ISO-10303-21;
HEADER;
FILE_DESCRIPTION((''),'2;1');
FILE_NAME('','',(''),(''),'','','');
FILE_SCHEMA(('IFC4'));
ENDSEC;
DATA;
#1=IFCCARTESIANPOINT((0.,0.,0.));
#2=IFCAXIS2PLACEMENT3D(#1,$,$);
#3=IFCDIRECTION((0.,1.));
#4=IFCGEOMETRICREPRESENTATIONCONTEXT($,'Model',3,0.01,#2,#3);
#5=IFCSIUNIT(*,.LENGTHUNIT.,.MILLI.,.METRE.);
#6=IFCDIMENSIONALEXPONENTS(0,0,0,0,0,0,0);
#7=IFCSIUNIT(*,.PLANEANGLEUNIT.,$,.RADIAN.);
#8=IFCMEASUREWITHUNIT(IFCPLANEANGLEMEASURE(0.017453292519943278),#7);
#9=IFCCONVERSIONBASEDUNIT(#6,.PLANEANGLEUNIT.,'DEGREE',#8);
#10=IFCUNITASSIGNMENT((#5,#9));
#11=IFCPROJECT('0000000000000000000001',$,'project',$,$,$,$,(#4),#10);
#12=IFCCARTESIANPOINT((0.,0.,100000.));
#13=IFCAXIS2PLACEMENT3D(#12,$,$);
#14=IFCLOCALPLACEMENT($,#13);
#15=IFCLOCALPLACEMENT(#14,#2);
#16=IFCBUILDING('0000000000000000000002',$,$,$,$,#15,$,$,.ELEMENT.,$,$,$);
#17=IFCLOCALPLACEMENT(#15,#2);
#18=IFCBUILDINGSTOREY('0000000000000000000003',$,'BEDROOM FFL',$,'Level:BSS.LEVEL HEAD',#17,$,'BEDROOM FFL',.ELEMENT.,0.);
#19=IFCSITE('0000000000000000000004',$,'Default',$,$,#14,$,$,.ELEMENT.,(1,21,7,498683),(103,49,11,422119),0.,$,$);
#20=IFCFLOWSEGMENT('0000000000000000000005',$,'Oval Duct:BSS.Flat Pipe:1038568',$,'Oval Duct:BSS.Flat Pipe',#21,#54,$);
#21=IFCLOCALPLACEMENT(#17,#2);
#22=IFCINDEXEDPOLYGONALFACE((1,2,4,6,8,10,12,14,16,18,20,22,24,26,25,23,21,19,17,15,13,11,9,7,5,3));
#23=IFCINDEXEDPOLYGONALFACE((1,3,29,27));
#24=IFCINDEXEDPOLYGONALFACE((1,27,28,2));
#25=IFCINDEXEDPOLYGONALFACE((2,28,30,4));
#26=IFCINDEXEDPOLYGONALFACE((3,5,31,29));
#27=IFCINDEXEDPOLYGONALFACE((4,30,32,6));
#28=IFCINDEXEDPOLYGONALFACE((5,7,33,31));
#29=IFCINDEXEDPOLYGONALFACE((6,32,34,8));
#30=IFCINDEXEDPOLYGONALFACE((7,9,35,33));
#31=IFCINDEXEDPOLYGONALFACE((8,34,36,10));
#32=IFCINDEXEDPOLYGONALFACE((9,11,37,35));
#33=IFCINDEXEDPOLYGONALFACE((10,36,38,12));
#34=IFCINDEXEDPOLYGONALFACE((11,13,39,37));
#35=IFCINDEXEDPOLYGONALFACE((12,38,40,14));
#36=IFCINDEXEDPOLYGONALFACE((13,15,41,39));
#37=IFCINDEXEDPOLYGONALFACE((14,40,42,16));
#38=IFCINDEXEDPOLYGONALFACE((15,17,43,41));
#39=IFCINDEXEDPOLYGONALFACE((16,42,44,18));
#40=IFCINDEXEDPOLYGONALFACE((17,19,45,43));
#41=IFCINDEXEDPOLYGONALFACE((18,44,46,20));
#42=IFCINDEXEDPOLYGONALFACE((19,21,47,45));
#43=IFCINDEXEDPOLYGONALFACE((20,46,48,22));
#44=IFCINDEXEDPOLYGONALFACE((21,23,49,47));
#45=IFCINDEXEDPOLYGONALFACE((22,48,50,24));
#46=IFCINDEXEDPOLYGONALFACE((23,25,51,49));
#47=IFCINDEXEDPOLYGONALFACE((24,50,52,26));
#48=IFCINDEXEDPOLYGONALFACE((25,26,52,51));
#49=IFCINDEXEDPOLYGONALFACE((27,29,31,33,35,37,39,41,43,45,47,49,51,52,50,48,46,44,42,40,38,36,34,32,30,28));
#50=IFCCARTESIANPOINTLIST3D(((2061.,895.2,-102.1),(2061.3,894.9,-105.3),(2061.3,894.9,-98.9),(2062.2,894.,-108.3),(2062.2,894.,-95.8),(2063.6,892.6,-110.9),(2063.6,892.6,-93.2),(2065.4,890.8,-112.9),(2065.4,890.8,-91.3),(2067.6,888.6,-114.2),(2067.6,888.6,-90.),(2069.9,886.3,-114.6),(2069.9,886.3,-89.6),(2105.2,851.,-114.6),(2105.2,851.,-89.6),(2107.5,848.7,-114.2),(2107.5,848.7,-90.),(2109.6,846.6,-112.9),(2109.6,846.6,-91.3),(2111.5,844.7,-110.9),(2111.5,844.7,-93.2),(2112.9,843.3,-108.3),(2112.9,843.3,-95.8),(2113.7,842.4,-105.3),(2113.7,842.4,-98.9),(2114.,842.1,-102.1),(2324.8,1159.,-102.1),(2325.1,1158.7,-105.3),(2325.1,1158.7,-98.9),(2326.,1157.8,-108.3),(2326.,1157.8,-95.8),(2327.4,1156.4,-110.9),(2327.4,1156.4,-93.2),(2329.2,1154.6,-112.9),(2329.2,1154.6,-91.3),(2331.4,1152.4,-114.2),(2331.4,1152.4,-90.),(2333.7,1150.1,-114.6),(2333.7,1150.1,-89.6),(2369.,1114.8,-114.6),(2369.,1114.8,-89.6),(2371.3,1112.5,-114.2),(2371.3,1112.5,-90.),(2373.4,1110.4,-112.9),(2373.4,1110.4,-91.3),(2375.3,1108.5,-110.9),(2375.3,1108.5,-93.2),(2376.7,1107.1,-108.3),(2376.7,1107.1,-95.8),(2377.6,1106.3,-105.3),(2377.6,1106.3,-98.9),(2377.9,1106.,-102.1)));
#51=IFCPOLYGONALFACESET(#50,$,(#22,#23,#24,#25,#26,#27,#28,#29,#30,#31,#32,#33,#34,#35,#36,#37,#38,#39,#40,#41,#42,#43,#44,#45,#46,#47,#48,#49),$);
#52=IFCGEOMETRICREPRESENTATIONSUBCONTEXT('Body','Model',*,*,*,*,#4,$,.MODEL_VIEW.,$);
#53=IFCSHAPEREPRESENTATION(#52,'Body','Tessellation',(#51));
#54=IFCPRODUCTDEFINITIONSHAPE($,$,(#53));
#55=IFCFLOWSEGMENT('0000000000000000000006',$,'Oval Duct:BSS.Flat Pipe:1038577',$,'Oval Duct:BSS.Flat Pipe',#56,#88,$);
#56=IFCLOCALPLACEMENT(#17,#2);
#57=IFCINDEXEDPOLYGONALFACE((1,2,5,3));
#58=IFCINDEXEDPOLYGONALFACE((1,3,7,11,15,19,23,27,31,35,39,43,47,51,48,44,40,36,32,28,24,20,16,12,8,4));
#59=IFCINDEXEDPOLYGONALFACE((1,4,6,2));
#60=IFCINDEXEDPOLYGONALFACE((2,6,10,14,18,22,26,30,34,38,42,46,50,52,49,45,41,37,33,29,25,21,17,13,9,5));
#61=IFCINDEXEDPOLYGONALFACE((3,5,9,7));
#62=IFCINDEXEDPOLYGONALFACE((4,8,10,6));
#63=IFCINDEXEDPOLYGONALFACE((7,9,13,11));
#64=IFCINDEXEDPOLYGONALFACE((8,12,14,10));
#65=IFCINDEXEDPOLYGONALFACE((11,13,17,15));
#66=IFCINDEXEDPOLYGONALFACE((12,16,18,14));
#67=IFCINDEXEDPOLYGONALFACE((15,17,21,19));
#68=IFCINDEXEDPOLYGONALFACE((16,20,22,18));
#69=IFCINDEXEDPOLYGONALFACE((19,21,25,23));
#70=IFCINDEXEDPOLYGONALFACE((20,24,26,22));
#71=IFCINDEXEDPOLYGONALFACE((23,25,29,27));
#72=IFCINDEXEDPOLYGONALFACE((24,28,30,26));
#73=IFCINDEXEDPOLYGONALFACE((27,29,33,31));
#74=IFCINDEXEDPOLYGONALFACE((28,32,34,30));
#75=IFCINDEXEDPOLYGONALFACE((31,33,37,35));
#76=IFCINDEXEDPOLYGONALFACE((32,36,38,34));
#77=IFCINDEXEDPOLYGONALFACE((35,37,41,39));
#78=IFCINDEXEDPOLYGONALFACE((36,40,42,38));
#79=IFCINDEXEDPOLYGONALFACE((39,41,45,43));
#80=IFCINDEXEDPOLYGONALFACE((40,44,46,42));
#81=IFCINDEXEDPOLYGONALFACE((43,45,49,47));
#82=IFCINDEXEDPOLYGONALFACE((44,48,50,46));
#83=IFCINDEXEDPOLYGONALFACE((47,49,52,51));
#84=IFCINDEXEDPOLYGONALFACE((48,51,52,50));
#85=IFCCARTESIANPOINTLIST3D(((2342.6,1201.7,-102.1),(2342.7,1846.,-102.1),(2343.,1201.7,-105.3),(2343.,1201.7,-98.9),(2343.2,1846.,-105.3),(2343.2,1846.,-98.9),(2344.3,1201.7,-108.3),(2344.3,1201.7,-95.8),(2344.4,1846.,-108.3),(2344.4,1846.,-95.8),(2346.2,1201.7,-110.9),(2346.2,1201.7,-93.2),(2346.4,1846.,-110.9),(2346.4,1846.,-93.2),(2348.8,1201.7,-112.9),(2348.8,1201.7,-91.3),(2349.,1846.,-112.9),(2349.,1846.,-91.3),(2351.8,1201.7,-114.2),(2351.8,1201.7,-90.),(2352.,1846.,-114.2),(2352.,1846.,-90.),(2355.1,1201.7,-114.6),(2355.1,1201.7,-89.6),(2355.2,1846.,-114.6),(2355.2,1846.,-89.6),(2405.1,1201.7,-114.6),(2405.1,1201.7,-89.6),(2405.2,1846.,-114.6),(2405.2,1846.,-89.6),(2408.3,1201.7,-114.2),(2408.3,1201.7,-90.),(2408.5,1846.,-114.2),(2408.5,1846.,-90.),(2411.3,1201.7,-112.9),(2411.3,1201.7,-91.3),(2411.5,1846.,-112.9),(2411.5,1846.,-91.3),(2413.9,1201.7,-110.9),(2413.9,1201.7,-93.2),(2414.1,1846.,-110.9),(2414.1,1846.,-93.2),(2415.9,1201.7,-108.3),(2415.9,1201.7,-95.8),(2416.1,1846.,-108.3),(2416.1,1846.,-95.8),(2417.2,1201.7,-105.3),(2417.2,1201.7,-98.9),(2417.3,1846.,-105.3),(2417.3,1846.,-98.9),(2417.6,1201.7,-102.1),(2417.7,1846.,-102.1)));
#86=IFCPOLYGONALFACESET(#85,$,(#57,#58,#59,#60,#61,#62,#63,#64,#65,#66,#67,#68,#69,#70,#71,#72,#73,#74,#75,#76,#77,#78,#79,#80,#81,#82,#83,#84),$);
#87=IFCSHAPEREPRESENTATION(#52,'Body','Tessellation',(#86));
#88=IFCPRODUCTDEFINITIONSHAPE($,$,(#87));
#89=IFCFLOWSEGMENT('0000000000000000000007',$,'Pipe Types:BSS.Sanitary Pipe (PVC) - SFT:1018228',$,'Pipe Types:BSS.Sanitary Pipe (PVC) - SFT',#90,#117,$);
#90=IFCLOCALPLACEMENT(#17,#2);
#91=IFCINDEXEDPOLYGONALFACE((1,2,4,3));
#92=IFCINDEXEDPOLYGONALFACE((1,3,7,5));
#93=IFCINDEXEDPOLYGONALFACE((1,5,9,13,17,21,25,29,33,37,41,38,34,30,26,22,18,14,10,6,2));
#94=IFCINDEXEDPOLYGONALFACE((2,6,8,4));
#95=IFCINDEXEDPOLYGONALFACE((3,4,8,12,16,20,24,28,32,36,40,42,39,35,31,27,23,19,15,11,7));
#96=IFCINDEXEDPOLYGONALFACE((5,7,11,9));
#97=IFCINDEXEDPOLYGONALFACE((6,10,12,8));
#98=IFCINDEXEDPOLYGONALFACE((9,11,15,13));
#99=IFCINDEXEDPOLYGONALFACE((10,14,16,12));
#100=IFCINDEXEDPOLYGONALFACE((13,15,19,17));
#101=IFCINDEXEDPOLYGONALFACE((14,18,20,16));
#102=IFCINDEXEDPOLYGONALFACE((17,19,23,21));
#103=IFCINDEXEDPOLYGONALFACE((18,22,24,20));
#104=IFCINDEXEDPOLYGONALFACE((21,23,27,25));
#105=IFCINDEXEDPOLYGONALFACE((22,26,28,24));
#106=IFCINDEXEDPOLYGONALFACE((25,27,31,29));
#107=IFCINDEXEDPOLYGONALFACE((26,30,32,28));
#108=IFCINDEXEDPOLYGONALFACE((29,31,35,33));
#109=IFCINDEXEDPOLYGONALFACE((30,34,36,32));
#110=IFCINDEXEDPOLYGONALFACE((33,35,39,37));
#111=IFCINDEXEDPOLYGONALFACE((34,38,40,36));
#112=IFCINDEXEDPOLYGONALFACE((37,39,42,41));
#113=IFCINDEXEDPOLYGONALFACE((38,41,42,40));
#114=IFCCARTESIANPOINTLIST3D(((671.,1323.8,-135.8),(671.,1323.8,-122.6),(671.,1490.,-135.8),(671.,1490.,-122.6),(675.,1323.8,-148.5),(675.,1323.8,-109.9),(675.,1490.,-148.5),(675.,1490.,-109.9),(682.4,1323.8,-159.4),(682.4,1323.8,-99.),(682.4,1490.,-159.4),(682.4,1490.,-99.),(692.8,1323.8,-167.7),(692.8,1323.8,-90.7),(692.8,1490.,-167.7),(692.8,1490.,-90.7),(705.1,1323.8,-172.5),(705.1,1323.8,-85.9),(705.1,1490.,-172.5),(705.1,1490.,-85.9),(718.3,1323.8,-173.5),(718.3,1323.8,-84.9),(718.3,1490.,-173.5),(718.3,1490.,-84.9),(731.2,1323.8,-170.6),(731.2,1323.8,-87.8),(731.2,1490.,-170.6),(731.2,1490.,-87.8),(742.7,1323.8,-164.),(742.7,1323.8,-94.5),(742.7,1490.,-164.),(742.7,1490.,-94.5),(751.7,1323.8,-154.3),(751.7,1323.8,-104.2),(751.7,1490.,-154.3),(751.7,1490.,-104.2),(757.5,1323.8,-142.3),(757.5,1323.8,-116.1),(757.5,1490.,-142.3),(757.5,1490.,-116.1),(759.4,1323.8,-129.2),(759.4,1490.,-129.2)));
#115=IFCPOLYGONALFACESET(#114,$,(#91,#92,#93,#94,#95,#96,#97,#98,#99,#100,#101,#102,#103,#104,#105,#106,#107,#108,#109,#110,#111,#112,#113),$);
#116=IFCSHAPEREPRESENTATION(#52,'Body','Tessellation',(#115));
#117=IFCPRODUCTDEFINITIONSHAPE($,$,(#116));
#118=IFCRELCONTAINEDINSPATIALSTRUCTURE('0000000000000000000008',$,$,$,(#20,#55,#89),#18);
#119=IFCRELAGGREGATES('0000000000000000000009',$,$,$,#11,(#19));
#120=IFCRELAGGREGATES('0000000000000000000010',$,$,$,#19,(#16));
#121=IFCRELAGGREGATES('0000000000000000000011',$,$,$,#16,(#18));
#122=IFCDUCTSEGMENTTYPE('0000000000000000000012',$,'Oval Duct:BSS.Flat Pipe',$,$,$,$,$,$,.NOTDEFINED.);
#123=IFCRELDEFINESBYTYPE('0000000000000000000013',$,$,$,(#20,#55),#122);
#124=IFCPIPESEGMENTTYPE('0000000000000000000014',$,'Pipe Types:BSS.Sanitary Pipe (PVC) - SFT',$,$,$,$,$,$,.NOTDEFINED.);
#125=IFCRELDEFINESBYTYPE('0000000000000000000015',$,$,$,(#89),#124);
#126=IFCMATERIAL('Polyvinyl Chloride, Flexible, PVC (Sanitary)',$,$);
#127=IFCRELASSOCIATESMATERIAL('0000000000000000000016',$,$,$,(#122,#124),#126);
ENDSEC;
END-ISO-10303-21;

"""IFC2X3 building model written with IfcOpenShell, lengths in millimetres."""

from ifc_helpers import new_model, entity, si_unit, converted_unit, direction, frame, frame_2d, origin, place, context, subcontext, project, spatial, polyline, circle_curve, parameter, trimmed, segment, composite_curve, circle, outline, extrude, material, type_object, element, save


model = new_model("IFC2X3")

# Units and contexts
model_context = context("Model", 3, precision=0.01, world=origin(), true_north=direction((0.0, 1.0)))
body_context = subcontext(model_context, "Body", "Model", "MODEL_VIEW")
ifc_project = project(units=[si_unit("LENGTHUNIT", "METRE", prefix="MILLI"), converted_unit("PLANEANGLEUNIT", "DEGREE", entity("IfcPlaneAngleMeasure", 0.017453292519943278), si_unit("PLANEANGLEUNIT", "RADIAN"), dimensions=[0, 0, 0, 0, 0, 0, 0])], contexts=[model_context])

# Site, building, storey
site_placement = place(None, frame((0.0, 0.0, 100000.0)))
site = spatial("IfcSite", under=ifc_project, at=site_placement, Name="Default", CompositionType="ELEMENT", RefLatitude=(1, 21, 7, 498683), RefLongitude=(103, 49, 11, 422119), RefElevation=0.0)
building_placement = place(site_placement, origin())
building = spatial("IfcBuilding", under=site, at=building_placement, CompositionType="ELEMENT")
storey_placement = place(building_placement, origin())
storey = spatial("IfcBuildingStorey", under=building, at=storey_placement, Name="BEDROOM FFL", ObjectType="Level:BSS.LEVEL HEAD", LongName="BEDROOM FFL", CompositionType="ELEMENT", Elevation=0.0)

# Flow segments
ifc_material_1 = material(Name="Polyvinyl Chloride, Flexible, PVC (Sanitary)")
duct_segment_type = type_object("IfcDuctSegmentType", Name="Oval Duct:BSS.Flat Pipe", PredefinedType="NOTDEFINED", material=ifc_material_1)
flow_segment_1_placement = place(storey_placement, origin())
element("IfcFlowSegment", 1, at=flow_segment_1_placement, inside=storey, type_object=duct_segment_type, Name="Oval Duct:BSS.Flat Pipe:1038568", ObjectType="Oval Duct:BSS.Flat Pipe", context=body_context, shape_type="SweptSolid", body=[
    extrude(outline(composite_curve([segment(trimmed(circle_curve(frame_2d((25.0, 0.0), x_axis=(1.0, 0.0)), 12.5), [parameter(270.0)], [parameter(0.0)], True, "PARAMETER"), True, "CONTINUOUS"), segment(trimmed(circle_curve(frame_2d((25.0, 0.0), x_axis=(1.0, 0.0)), 12.5), [parameter(0.0)], [parameter(90.0)], True, "PARAMETER"), True, "CONTINUOUS"), segment(polyline([(25.0, 12.5), (-25.0, 12.5)]), True, "CONTINUOUS"), segment(trimmed(circle_curve(frame_2d((-25.0, 0.0), x_axis=(1.0, 0.0)), 12.5), [parameter(90.0)], [parameter(180.0)], True, "PARAMETER"), True, "CONTINUOUS"), segment(trimmed(circle_curve(frame_2d((-25.0, 0.0), x_axis=(1.0, 0.0)), 12.5), [parameter(180.0)], [parameter(270.0)], True, "PARAMETER"), True, "CONTINUOUS"), segment(polyline([(-25.0, -12.5), (25.0, -12.5)]), True, "CONTINUOUS")], self_intersect=False)), frame((2087.5, 868.7, -102.1), z_axis=(0.707107, 0.707107, 0.0), x_axis=(0.707107, -0.707107, 0.0)), (0.0, 0.0, 1.0), 373.1),
])
flow_segment_2_placement = place(storey_placement, origin())
element("IfcFlowSegment", 2, at=flow_segment_2_placement, inside=storey, type_object=duct_segment_type, Name="Oval Duct:BSS.Flat Pipe:1038577", ObjectType="Oval Duct:BSS.Flat Pipe", context=body_context, shape_type="SweptSolid", body=[
    extrude(outline(composite_curve([segment(trimmed(circle_curve(frame_2d((25.0, 0.0), x_axis=(1.0, 0.0)), 12.5), [parameter(270.0)], [parameter(0.0)], True, "PARAMETER"), True, "CONTINUOUS"), segment(trimmed(circle_curve(frame_2d((25.0, 0.0), x_axis=(1.0, 0.0)), 12.5), [parameter(0.0)], [parameter(90.0)], True, "PARAMETER"), True, "CONTINUOUS"), segment(polyline([(25.0, 12.5), (-25.0, 12.5)]), True, "CONTINUOUS"), segment(trimmed(circle_curve(frame_2d((-25.0, 0.0), x_axis=(1.0, 0.0)), 12.5), [parameter(90.0)], [parameter(180.0)], True, "PARAMETER"), True, "CONTINUOUS"), segment(trimmed(circle_curve(frame_2d((-25.0, 0.0), x_axis=(1.0, 0.0)), 12.5), [parameter(180.0)], [parameter(270.0)], True, "PARAMETER"), True, "CONTINUOUS"), segment(polyline([(-25.0, -12.5), (25.0, -12.5)]), True, "CONTINUOUS")], self_intersect=False)), frame((2380.1, 1201.7, -102.1), z_axis=(0.000256, 1.0, 0.0), x_axis=(1.0, -0.000256, 0.0)), (0.0, 0.0, 1.0), 644.3),
])
pipe_segment_type_1 = type_object("IfcPipeSegmentType", Name="Pipe Types:BSS.Sanitary Pipe (PVC) - SFT", PredefinedType="NOTDEFINED", material=ifc_material_1)
flow_segment_3_placement = place(storey_placement, origin())
element("IfcFlowSegment", 3, at=flow_segment_3_placement, inside=storey, type_object=pipe_segment_type_1, Name="Pipe Types:BSS.Sanitary Pipe (PVC) - SFT:1018228", ObjectType="Pipe Types:BSS.Sanitary Pipe (PVC) - SFT", context=body_context, shape_type="SweptSolid", body=[
    extrude(circle(Radius=44.5, at=frame_2d((0.0, 0.0), x_axis=(1.0, 0.0))), frame((715.0, 1323.8, -129.2), z_axis=(0.0, 1.0, 0.0), x_axis=(1.0, 0.0, 0.0)), (0.0, 0.0, 1.0), 166.2),
])

save(model, "model.ifc")
